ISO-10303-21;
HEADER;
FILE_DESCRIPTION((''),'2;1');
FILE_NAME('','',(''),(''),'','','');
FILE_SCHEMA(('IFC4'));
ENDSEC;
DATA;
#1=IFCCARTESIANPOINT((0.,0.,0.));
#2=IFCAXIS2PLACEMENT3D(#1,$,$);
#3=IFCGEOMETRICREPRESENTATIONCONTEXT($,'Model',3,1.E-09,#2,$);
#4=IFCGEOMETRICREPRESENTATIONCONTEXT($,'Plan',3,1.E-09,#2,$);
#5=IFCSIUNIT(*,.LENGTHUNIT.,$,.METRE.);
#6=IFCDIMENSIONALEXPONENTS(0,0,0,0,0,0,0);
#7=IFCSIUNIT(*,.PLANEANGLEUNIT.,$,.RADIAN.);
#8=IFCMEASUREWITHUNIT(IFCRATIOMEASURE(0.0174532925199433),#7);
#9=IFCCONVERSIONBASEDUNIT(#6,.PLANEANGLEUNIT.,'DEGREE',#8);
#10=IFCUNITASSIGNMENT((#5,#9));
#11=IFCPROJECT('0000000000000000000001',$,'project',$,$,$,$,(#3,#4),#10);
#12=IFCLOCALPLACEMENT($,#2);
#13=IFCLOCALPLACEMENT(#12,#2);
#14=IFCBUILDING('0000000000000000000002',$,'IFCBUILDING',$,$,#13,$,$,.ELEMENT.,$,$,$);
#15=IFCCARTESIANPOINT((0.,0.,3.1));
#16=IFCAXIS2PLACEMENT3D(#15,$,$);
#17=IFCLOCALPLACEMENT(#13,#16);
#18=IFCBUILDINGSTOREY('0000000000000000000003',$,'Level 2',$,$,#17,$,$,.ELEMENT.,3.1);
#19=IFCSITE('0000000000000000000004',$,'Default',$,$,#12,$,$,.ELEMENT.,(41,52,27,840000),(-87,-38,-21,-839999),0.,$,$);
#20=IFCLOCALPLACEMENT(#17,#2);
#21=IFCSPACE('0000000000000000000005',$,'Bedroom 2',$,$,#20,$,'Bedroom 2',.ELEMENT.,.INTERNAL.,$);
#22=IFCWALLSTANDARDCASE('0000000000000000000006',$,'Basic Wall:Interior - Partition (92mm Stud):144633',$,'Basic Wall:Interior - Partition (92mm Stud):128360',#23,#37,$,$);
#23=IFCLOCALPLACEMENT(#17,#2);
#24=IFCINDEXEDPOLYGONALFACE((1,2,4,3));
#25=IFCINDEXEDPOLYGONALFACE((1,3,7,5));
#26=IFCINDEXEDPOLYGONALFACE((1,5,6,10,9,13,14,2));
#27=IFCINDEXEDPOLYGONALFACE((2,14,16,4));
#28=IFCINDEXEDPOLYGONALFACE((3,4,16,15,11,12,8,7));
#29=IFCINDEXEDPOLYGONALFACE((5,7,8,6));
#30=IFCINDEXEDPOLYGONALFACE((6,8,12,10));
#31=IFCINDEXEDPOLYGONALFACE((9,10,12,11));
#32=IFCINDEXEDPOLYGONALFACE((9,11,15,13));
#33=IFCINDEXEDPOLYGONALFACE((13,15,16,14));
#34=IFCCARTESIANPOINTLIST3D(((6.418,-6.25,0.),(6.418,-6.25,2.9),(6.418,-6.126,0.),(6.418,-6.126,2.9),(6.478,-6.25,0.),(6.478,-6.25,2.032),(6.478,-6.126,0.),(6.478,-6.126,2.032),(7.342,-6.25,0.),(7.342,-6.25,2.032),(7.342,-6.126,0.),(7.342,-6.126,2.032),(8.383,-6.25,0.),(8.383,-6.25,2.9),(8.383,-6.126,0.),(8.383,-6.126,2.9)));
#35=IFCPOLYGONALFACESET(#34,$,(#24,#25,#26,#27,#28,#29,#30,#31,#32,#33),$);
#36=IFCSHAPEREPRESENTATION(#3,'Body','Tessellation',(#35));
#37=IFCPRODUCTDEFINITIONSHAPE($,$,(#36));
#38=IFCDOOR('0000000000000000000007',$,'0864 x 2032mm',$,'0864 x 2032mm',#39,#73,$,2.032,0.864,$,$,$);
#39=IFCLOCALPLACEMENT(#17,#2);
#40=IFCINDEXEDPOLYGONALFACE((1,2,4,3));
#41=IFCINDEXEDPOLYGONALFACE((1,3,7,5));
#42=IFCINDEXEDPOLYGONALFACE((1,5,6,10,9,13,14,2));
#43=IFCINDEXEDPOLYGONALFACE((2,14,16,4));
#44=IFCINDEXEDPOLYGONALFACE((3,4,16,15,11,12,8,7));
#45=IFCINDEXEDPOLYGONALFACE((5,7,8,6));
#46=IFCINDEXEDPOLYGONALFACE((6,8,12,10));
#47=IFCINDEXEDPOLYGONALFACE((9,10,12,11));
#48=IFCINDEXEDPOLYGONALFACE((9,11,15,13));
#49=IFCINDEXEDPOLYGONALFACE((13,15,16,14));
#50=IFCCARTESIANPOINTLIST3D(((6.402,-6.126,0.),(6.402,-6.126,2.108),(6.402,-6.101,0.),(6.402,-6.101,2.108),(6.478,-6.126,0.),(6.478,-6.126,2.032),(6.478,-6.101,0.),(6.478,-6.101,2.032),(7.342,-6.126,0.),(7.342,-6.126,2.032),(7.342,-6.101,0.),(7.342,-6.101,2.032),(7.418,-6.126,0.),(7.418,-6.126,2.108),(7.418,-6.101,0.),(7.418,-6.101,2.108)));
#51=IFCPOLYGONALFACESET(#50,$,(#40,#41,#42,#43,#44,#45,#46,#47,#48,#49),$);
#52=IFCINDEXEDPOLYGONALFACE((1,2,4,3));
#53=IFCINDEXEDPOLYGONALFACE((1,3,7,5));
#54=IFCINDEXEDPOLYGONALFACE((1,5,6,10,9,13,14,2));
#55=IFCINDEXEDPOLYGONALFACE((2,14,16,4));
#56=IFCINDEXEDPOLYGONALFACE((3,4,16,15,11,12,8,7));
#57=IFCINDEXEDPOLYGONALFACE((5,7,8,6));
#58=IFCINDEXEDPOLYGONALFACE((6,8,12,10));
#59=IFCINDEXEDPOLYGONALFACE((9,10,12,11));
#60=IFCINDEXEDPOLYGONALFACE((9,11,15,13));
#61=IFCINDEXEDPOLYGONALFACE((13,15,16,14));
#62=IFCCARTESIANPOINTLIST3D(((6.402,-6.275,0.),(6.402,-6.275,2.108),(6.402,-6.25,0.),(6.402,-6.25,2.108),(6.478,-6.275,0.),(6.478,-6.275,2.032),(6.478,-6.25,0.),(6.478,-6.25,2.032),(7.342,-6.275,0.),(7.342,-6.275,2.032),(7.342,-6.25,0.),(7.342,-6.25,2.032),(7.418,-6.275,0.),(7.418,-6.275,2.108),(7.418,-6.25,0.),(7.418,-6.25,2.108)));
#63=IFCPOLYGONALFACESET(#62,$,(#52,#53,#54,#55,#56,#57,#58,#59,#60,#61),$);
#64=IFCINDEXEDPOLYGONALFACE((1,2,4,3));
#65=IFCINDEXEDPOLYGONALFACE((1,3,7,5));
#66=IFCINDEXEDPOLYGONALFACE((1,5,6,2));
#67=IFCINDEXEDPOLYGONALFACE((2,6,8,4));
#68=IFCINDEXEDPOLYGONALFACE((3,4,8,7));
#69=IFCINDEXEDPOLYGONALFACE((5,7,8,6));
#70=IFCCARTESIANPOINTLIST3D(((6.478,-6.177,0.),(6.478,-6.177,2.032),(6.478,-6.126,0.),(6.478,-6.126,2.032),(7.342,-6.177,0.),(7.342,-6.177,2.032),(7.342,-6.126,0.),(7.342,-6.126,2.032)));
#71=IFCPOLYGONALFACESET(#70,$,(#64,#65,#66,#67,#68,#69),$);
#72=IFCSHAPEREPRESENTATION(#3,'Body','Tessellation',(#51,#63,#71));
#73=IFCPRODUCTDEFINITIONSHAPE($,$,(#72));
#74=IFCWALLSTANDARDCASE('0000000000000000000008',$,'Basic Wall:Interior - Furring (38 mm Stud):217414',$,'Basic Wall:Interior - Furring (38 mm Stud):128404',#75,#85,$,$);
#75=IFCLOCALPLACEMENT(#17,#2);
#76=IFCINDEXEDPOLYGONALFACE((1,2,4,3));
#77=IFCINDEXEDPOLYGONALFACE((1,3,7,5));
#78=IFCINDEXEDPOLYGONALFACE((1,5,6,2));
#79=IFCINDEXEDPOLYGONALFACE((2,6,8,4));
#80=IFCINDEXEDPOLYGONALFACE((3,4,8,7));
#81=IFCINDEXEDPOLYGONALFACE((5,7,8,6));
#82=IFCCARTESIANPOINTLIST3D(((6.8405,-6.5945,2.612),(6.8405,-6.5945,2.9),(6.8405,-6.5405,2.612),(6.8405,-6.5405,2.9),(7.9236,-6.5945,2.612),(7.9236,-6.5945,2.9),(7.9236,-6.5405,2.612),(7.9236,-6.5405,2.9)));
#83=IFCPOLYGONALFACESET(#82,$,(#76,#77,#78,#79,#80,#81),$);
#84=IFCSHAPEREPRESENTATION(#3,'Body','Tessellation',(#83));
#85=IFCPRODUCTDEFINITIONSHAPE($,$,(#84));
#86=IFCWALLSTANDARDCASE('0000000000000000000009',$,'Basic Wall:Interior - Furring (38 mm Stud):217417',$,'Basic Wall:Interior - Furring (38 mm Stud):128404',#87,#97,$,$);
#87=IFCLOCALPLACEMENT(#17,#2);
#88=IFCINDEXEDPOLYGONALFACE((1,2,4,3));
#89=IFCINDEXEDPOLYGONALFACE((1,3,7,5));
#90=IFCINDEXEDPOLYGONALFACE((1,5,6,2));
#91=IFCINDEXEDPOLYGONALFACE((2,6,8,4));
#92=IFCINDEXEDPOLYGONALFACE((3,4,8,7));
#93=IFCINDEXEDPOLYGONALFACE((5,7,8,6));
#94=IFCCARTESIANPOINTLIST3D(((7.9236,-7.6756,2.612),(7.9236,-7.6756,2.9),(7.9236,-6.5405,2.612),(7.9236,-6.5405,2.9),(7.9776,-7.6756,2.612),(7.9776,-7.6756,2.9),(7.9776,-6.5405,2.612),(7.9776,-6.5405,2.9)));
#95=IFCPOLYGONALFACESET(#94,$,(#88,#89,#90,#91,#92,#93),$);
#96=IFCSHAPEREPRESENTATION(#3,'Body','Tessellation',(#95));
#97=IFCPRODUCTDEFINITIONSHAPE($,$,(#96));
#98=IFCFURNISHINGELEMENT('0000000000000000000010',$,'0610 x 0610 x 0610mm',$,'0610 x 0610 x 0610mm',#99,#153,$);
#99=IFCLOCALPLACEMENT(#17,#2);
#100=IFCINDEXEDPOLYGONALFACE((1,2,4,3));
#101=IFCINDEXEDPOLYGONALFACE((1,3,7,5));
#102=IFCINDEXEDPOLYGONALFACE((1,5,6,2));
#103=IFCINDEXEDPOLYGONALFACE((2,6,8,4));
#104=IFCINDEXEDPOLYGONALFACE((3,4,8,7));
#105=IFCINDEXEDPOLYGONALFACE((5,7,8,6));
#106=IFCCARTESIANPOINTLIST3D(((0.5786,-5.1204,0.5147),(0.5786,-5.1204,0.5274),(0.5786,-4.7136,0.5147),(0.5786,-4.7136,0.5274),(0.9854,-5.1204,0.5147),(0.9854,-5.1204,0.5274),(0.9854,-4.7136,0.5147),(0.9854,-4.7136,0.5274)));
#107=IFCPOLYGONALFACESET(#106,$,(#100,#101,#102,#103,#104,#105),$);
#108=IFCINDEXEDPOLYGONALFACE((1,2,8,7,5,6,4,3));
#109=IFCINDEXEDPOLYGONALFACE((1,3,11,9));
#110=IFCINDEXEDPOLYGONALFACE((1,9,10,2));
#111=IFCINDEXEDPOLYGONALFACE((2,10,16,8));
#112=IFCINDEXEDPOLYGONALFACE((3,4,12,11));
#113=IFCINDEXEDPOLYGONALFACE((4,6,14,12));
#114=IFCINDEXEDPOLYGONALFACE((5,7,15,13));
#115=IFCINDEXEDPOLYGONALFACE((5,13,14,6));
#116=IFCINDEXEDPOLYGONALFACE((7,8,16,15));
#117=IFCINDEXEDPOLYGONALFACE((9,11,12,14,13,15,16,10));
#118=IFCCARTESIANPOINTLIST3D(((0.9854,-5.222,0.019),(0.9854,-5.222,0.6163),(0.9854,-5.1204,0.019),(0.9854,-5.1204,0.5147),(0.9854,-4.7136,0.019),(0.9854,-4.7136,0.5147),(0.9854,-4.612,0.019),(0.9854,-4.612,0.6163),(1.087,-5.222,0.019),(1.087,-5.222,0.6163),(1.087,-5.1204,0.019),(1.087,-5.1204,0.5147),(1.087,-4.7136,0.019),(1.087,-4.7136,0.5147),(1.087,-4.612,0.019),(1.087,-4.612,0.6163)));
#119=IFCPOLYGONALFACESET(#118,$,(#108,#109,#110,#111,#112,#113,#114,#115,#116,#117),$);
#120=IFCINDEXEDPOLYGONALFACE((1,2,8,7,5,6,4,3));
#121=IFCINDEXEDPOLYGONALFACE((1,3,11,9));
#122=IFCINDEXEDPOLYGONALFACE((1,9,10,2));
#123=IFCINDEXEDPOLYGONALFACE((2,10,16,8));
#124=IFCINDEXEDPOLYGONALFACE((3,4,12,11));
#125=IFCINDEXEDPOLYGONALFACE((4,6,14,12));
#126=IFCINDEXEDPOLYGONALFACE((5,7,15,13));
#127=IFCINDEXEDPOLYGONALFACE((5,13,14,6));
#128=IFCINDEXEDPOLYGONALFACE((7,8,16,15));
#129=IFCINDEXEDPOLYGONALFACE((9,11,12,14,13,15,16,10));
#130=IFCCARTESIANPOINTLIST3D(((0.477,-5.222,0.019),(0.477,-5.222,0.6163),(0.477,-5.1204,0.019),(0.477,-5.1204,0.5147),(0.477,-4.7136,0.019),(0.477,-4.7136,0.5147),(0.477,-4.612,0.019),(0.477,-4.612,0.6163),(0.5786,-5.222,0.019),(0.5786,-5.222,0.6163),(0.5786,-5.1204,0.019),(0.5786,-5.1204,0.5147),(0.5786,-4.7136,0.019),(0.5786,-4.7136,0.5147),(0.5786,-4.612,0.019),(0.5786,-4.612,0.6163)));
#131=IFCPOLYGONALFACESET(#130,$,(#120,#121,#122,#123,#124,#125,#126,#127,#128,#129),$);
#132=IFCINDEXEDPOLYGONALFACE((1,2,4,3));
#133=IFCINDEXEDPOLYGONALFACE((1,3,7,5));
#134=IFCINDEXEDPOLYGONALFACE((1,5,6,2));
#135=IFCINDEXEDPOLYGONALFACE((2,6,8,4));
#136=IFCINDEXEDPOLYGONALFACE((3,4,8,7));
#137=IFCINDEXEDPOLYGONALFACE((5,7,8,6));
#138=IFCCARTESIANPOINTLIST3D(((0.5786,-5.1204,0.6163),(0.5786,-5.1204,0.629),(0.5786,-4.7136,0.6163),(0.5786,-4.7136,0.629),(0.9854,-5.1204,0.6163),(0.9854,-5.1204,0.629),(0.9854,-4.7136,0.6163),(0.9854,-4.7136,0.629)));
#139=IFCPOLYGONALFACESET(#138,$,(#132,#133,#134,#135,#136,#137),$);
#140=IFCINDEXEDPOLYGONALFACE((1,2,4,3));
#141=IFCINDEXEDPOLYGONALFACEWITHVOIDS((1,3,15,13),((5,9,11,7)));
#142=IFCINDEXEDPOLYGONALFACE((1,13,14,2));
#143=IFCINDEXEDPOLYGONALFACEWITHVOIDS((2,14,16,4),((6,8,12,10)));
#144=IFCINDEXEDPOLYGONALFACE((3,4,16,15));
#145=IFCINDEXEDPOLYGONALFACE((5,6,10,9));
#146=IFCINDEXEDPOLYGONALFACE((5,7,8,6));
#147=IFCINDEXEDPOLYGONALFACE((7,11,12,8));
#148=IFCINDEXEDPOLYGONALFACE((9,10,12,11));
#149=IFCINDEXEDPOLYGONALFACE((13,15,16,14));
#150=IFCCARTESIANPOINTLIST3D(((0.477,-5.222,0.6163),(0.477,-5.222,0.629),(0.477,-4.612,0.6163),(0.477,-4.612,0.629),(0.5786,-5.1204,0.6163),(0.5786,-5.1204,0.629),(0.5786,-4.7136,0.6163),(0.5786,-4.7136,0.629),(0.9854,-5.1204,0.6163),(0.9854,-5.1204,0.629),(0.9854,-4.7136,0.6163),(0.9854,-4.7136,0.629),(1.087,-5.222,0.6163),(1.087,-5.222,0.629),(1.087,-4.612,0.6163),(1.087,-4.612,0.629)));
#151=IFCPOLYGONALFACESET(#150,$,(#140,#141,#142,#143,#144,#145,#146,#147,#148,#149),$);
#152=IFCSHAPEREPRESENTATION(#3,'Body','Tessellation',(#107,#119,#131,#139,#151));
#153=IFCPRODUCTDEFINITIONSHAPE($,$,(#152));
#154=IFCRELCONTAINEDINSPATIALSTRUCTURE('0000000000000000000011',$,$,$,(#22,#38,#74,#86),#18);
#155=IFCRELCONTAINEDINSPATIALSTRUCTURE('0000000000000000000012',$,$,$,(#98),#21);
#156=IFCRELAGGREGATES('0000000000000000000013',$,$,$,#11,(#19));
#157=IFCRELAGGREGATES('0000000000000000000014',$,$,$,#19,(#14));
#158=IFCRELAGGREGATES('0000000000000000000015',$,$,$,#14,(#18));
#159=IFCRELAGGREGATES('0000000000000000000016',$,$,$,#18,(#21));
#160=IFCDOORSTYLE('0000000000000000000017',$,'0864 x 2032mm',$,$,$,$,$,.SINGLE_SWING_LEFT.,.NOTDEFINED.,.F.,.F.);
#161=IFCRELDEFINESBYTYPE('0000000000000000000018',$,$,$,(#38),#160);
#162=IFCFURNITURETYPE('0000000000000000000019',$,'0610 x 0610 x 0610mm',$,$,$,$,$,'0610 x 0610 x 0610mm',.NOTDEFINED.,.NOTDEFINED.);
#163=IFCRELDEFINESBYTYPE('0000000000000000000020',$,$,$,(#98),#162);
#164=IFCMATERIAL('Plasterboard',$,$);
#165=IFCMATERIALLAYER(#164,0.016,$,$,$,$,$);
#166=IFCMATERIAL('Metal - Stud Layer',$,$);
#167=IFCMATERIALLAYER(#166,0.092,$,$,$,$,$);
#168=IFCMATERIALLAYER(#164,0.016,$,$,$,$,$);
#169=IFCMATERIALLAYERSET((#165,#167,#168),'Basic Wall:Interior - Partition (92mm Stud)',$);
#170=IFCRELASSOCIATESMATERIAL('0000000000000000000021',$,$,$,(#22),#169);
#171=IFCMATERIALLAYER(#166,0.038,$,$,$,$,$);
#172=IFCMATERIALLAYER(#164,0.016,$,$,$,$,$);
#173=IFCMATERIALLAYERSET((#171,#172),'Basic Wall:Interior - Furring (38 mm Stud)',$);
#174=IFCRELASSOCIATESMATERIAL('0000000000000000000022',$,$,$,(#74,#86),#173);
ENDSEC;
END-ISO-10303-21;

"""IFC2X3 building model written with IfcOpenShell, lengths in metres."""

from ifc_helpers import new_model, entity, si_unit, converted_unit, frame, frame_2d, origin, origin_2d_with_axis, place, context, project, spatial, polyline, rectangle, outline, extrude, source, transform, mapped, material, layer, layer_set, layer_usage, type_object, type_shapes, element, fill, save


model = new_model("IFC2X3")

# Units and contexts
model_context = context("Model", 3, precision=1e-09, world=origin())
plan_context = context("Plan", 3, precision=1e-09, world=origin())
ifc_project = project(units=[si_unit("LENGTHUNIT", "METRE"), converted_unit("PLANEANGLEUNIT", "DEGREE", entity("IfcRatioMeasure", 0.0174532925199433), si_unit("PLANEANGLEUNIT", "RADIAN"), dimensions=[0, 0, 0, 0, 0, 0, 0])], contexts=[model_context, plan_context])

# Site, building, storey
site_placement = place(None, origin())
site = spatial("IfcSite", under=ifc_project, at=site_placement, Name="Default", CompositionType="ELEMENT", RefLatitude=(41, 52, 27, 840000), RefLongitude=(-87, -38, -21, -839999), RefElevation=0.0)
building_placement = place(site_placement, origin())
building = spatial("IfcBuilding", under=site, at=building_placement, Name="IFCBUILDING", CompositionType="ELEMENT")
storey_placement = place(building_placement, frame((0.0, 0.0, 3.1)))
storey = spatial("IfcBuildingStorey", under=building, at=storey_placement, Name="Level 2", CompositionType="ELEMENT", Elevation=3.1)

# Shared definitions
ifc_material_1 = material(Name="Metal - Stud Layer")
ifc_material_2 = material(Name="Plasterboard")

# Wall, opening, door
ifc_layer_1 = layer(ifc_material_2, 0.016)
ifc_layer_2 = layer(ifc_material_1, 0.092)
ifc_layer_3 = layer(ifc_material_2, 0.016)
ifc_layer_set_1 = layer_set([ifc_layer_1, ifc_layer_2, ifc_layer_3], Name="Basic Wall:Interior - Partition (92mm Stud)")
ifc_layer_usage_1 = layer_usage(ifc_layer_set_1, "AXIS2", "NEGATIVE", 0.062)
wall_1_placement = place(storey_placement, frame((6.418, -6.188, 0.0)))
wall_1 = element("IfcWallStandardCase", 1, at=wall_1_placement, inside=storey, material=ifc_layer_usage_1, Name="Basic Wall:Interior - Partition (92mm Stud):144633", ObjectType="Basic Wall:Interior - Partition (92mm Stud):128360", context=model_context, shape_type="SweptSolid", body=[
    extrude(rectangle(XDim=1.965, YDim=0.124, at=frame_2d((0.9825, 0.0), x_axis=(-1.0, 0.0))), origin(), (0.0, 0.0, 1.0), 2.9),
])
opening_1_placement = place(wall_1_placement, frame((0.06, -0.062, 0.0)))
opening_1 = element("IfcOpeningElement", 2, at=opening_1_placement, cuts=wall_1, ObjectType="Opening", context=model_context, shape_type="SweptSolid", body=[
    extrude(rectangle(XDim=0.864, YDim=2.032, at=frame_2d((1.016, 0.432), x_axis=(0.0, -1.0))), frame((0.0, 0.0, 0.0), z_axis=(0.0, 1.0, 0.0), x_axis=(0.0, 0.0, 1.0)), (0.0, 0.0, 1.0), 0.124),
])
door_style_1 = type_object("IfcDoorStyle", Name="0864 x 2032mm", ConstructionType="NOTDEFINED", OperationType="SINGLE_SWING_LEFT", ParameterTakesPrecedence=False, Sizeable=False)
shared_shape_1 = source(origin(), model_context, "Body", "SweptSolid", [
    extrude(outline(polyline([(-0.508, -1.073), (0.508, -1.073), (0.508, 1.035), (0.432, 1.035), (0.432, -0.997), (-0.432, -0.997), (-0.432, 1.035), (-0.508, 1.035), (-0.508, -1.073)])), frame((0.432, 0.149, 1.035), z_axis=(0.0, -1.0, 0.0), x_axis=(-1.0, 0.0, 0.0)), (0.0, 0.0, 1.0), 0.025),
    extrude(outline(polyline([(-1.073, -0.508), (1.035, -0.508), (1.035, -0.432), (-0.997, -0.432), (-0.997, 0.432), (1.035, 0.432), (1.035, 0.508), (-1.073, 0.508), (-1.073, -0.508)])), frame((0.432, 0.0, 1.035), z_axis=(0.0, -1.0, 0.0), x_axis=(0.0, 0.0, -1.0)), (0.0, 0.0, 1.0), 0.025),
    extrude(rectangle(XDim=0.864, YDim=0.051, at=origin_2d_with_axis()), frame((0.432, 0.0985, 0.0)), (0.0, 0.0, 1.0), 2.032),
])
type_shapes(door_style_1, [shared_shape_1])
door_1_placement = place(opening_1_placement, origin())
door_1 = element("IfcDoor", 3, at=door_1_placement, inside=storey, type_object=door_style_1, Name="0864 x 2032mm", ObjectType="0864 x 2032mm", OverallHeight=2.032, OverallWidth=0.864, context=model_context, shape_type="MappedRepresentation", body=[
    mapped(shared_shape_1, transform((0.0, 0.0, 0.0), scale=1.0)),
])
fill(opening_1, door_1)

# Walls
ifc_layer_4 = layer(ifc_material_1, 0.038)
ifc_layer_5 = layer(ifc_material_2, 0.016)
ifc_layer_set_2 = layer_set([ifc_layer_4, ifc_layer_5], Name="Basic Wall:Interior - Furring (38 mm Stud)")
ifc_layer_usage_2 = layer_usage(ifc_layer_set_2, "AXIS2", "NEGATIVE", 0.027)
wall_2_placement = place(storey_placement, frame((6.8405, -6.5675, 2.612)))
element("IfcWallStandardCase", 4, at=wall_2_placement, inside=storey, material=ifc_layer_usage_2, Name="Basic Wall:Interior - Furring (38 mm Stud):217414", ObjectType="Basic Wall:Interior - Furring (38 mm Stud):128404", context=model_context, shape_type="SweptSolid", body=[
    extrude(rectangle(XDim=1.0831, YDim=0.054, at=frame_2d((0.5415, 0.0), x_axis=(-1.0, 0.0))), origin(), (0.0, 0.0, 1.0), 0.288),
])
ifc_layer_usage_3 = layer_usage(ifc_layer_set_2, "AXIS2", "NEGATIVE", 0.027)
wall_3_placement = place(storey_placement, frame((7.9506, -6.5405, 2.612), z_axis=(0.0, 0.0, 1.0), x_axis=(0.0, -1.0, 0.0)))
element("IfcWallStandardCase", 5, at=wall_3_placement, inside=storey, material=ifc_layer_usage_3, Name="Basic Wall:Interior - Furring (38 mm Stud):217417", ObjectType="Basic Wall:Interior - Furring (38 mm Stud):128404", context=model_context, shape_type="SweptSolid", body=[
    extrude(rectangle(XDim=1.1351, YDim=0.054, at=frame_2d((0.5675, 0.0), x_axis=(-1.0, 0.0))), origin(), (0.0, 0.0, 1.0), 0.288),
])

# Shared definitions
space_1_placement = place(storey_placement, origin())
space_1 = spatial("IfcSpace", under=storey, at=space_1_placement, Name="Bedroom 2", LongName="Bedroom 2", CompositionType="ELEMENT", InteriorOrExteriorSpace="INTERNAL")

# Furnishing element
furniture_type = type_object("IfcFurnitureType", Name="0610 x 0610 x 0610mm", ElementType="0610 x 0610 x 0610mm", AssemblyPlace="NOTDEFINED")
shared_shape_2 = source(origin(), model_context, "Body", "SweptSolid", [
    extrude(rectangle(XDim=0.4068, YDim=0.4068, at=origin_2d_with_axis()), frame((0.0183, 0.0952, 0.4957), z_axis=(0.0, 0.0, 1.0), x_axis=(-1.0, 0.0, 0.0)), (0.0, 0.0, 1.0), 0.0127),
    extrude(outline(polyline([(-0.2732, -0.305), (0.324, -0.305), (0.324, 0.305), (-0.2732, 0.305), (-0.2732, 0.2034), (0.2225, 0.2034), (0.2225, -0.2034), (-0.2732, -0.2034), (-0.2732, -0.305)])), frame((0.2217, 0.0952, 0.2732), z_axis=(1.0, 0.0, 0.0), x_axis=(0.0, 0.0, 1.0)), (0.0, 0.0, 1.0), 0.1016),
    extrude(outline(polyline([(-0.305, -0.3241), (0.305, -0.3241), (0.305, 0.2733), (0.2034, 0.2733), (0.2034, -0.2224), (-0.2034, -0.2224), (-0.2034, 0.2733), (-0.305, 0.2733), (-0.305, -0.3241)])), frame((-0.2867, 0.0952, 0.2733), z_axis=(1.0, 0.0, 0.0), x_axis=(0.0, -1.0, 0.0)), (0.0, 0.0, 1.0), 0.1016),
    extrude(rectangle(XDim=0.4068, YDim=0.4068, at=origin_2d_with_axis()), frame((0.0183, 0.0952, 0.5973), z_axis=(0.0, 0.0, 1.0), x_axis=(-1.0, 0.0, 0.0)), (0.0, 0.0, 1.0), 0.0127),
    extrude(outline(polyline([(-0.305, -0.305), (0.305, -0.305), (0.305, 0.305), (-0.305, 0.305), (-0.305, -0.305)]), holes=[polyline([(-0.2034, -0.2034), (-0.2034, 0.2034), (0.2034, 0.2034), (0.2034, -0.2034), (-0.2034, -0.2034)])]), frame((0.0183, 0.0952, 0.5973), z_axis=(0.0, 0.0, 1.0), x_axis=(-1.0, 0.0, 0.0)), (0.0, 0.0, 1.0), 0.0127),
])
type_shapes(furniture_type, [shared_shape_2])
furnishing_1_placement = place(space_1_placement, frame((0.7637, -5.0122, 0.019)))
element("IfcFurnishingElement", 6, at=furnishing_1_placement, inside=space_1, type_object=furniture_type, Name="0610 x 0610 x 0610mm", ObjectType="0610 x 0610 x 0610mm", context=model_context, shape_type="MappedRepresentation", body=[
    mapped(shared_shape_2, transform((0.0, 0.0, 0.0), scale=1.0)),
])

save(model, "model.ifc")
